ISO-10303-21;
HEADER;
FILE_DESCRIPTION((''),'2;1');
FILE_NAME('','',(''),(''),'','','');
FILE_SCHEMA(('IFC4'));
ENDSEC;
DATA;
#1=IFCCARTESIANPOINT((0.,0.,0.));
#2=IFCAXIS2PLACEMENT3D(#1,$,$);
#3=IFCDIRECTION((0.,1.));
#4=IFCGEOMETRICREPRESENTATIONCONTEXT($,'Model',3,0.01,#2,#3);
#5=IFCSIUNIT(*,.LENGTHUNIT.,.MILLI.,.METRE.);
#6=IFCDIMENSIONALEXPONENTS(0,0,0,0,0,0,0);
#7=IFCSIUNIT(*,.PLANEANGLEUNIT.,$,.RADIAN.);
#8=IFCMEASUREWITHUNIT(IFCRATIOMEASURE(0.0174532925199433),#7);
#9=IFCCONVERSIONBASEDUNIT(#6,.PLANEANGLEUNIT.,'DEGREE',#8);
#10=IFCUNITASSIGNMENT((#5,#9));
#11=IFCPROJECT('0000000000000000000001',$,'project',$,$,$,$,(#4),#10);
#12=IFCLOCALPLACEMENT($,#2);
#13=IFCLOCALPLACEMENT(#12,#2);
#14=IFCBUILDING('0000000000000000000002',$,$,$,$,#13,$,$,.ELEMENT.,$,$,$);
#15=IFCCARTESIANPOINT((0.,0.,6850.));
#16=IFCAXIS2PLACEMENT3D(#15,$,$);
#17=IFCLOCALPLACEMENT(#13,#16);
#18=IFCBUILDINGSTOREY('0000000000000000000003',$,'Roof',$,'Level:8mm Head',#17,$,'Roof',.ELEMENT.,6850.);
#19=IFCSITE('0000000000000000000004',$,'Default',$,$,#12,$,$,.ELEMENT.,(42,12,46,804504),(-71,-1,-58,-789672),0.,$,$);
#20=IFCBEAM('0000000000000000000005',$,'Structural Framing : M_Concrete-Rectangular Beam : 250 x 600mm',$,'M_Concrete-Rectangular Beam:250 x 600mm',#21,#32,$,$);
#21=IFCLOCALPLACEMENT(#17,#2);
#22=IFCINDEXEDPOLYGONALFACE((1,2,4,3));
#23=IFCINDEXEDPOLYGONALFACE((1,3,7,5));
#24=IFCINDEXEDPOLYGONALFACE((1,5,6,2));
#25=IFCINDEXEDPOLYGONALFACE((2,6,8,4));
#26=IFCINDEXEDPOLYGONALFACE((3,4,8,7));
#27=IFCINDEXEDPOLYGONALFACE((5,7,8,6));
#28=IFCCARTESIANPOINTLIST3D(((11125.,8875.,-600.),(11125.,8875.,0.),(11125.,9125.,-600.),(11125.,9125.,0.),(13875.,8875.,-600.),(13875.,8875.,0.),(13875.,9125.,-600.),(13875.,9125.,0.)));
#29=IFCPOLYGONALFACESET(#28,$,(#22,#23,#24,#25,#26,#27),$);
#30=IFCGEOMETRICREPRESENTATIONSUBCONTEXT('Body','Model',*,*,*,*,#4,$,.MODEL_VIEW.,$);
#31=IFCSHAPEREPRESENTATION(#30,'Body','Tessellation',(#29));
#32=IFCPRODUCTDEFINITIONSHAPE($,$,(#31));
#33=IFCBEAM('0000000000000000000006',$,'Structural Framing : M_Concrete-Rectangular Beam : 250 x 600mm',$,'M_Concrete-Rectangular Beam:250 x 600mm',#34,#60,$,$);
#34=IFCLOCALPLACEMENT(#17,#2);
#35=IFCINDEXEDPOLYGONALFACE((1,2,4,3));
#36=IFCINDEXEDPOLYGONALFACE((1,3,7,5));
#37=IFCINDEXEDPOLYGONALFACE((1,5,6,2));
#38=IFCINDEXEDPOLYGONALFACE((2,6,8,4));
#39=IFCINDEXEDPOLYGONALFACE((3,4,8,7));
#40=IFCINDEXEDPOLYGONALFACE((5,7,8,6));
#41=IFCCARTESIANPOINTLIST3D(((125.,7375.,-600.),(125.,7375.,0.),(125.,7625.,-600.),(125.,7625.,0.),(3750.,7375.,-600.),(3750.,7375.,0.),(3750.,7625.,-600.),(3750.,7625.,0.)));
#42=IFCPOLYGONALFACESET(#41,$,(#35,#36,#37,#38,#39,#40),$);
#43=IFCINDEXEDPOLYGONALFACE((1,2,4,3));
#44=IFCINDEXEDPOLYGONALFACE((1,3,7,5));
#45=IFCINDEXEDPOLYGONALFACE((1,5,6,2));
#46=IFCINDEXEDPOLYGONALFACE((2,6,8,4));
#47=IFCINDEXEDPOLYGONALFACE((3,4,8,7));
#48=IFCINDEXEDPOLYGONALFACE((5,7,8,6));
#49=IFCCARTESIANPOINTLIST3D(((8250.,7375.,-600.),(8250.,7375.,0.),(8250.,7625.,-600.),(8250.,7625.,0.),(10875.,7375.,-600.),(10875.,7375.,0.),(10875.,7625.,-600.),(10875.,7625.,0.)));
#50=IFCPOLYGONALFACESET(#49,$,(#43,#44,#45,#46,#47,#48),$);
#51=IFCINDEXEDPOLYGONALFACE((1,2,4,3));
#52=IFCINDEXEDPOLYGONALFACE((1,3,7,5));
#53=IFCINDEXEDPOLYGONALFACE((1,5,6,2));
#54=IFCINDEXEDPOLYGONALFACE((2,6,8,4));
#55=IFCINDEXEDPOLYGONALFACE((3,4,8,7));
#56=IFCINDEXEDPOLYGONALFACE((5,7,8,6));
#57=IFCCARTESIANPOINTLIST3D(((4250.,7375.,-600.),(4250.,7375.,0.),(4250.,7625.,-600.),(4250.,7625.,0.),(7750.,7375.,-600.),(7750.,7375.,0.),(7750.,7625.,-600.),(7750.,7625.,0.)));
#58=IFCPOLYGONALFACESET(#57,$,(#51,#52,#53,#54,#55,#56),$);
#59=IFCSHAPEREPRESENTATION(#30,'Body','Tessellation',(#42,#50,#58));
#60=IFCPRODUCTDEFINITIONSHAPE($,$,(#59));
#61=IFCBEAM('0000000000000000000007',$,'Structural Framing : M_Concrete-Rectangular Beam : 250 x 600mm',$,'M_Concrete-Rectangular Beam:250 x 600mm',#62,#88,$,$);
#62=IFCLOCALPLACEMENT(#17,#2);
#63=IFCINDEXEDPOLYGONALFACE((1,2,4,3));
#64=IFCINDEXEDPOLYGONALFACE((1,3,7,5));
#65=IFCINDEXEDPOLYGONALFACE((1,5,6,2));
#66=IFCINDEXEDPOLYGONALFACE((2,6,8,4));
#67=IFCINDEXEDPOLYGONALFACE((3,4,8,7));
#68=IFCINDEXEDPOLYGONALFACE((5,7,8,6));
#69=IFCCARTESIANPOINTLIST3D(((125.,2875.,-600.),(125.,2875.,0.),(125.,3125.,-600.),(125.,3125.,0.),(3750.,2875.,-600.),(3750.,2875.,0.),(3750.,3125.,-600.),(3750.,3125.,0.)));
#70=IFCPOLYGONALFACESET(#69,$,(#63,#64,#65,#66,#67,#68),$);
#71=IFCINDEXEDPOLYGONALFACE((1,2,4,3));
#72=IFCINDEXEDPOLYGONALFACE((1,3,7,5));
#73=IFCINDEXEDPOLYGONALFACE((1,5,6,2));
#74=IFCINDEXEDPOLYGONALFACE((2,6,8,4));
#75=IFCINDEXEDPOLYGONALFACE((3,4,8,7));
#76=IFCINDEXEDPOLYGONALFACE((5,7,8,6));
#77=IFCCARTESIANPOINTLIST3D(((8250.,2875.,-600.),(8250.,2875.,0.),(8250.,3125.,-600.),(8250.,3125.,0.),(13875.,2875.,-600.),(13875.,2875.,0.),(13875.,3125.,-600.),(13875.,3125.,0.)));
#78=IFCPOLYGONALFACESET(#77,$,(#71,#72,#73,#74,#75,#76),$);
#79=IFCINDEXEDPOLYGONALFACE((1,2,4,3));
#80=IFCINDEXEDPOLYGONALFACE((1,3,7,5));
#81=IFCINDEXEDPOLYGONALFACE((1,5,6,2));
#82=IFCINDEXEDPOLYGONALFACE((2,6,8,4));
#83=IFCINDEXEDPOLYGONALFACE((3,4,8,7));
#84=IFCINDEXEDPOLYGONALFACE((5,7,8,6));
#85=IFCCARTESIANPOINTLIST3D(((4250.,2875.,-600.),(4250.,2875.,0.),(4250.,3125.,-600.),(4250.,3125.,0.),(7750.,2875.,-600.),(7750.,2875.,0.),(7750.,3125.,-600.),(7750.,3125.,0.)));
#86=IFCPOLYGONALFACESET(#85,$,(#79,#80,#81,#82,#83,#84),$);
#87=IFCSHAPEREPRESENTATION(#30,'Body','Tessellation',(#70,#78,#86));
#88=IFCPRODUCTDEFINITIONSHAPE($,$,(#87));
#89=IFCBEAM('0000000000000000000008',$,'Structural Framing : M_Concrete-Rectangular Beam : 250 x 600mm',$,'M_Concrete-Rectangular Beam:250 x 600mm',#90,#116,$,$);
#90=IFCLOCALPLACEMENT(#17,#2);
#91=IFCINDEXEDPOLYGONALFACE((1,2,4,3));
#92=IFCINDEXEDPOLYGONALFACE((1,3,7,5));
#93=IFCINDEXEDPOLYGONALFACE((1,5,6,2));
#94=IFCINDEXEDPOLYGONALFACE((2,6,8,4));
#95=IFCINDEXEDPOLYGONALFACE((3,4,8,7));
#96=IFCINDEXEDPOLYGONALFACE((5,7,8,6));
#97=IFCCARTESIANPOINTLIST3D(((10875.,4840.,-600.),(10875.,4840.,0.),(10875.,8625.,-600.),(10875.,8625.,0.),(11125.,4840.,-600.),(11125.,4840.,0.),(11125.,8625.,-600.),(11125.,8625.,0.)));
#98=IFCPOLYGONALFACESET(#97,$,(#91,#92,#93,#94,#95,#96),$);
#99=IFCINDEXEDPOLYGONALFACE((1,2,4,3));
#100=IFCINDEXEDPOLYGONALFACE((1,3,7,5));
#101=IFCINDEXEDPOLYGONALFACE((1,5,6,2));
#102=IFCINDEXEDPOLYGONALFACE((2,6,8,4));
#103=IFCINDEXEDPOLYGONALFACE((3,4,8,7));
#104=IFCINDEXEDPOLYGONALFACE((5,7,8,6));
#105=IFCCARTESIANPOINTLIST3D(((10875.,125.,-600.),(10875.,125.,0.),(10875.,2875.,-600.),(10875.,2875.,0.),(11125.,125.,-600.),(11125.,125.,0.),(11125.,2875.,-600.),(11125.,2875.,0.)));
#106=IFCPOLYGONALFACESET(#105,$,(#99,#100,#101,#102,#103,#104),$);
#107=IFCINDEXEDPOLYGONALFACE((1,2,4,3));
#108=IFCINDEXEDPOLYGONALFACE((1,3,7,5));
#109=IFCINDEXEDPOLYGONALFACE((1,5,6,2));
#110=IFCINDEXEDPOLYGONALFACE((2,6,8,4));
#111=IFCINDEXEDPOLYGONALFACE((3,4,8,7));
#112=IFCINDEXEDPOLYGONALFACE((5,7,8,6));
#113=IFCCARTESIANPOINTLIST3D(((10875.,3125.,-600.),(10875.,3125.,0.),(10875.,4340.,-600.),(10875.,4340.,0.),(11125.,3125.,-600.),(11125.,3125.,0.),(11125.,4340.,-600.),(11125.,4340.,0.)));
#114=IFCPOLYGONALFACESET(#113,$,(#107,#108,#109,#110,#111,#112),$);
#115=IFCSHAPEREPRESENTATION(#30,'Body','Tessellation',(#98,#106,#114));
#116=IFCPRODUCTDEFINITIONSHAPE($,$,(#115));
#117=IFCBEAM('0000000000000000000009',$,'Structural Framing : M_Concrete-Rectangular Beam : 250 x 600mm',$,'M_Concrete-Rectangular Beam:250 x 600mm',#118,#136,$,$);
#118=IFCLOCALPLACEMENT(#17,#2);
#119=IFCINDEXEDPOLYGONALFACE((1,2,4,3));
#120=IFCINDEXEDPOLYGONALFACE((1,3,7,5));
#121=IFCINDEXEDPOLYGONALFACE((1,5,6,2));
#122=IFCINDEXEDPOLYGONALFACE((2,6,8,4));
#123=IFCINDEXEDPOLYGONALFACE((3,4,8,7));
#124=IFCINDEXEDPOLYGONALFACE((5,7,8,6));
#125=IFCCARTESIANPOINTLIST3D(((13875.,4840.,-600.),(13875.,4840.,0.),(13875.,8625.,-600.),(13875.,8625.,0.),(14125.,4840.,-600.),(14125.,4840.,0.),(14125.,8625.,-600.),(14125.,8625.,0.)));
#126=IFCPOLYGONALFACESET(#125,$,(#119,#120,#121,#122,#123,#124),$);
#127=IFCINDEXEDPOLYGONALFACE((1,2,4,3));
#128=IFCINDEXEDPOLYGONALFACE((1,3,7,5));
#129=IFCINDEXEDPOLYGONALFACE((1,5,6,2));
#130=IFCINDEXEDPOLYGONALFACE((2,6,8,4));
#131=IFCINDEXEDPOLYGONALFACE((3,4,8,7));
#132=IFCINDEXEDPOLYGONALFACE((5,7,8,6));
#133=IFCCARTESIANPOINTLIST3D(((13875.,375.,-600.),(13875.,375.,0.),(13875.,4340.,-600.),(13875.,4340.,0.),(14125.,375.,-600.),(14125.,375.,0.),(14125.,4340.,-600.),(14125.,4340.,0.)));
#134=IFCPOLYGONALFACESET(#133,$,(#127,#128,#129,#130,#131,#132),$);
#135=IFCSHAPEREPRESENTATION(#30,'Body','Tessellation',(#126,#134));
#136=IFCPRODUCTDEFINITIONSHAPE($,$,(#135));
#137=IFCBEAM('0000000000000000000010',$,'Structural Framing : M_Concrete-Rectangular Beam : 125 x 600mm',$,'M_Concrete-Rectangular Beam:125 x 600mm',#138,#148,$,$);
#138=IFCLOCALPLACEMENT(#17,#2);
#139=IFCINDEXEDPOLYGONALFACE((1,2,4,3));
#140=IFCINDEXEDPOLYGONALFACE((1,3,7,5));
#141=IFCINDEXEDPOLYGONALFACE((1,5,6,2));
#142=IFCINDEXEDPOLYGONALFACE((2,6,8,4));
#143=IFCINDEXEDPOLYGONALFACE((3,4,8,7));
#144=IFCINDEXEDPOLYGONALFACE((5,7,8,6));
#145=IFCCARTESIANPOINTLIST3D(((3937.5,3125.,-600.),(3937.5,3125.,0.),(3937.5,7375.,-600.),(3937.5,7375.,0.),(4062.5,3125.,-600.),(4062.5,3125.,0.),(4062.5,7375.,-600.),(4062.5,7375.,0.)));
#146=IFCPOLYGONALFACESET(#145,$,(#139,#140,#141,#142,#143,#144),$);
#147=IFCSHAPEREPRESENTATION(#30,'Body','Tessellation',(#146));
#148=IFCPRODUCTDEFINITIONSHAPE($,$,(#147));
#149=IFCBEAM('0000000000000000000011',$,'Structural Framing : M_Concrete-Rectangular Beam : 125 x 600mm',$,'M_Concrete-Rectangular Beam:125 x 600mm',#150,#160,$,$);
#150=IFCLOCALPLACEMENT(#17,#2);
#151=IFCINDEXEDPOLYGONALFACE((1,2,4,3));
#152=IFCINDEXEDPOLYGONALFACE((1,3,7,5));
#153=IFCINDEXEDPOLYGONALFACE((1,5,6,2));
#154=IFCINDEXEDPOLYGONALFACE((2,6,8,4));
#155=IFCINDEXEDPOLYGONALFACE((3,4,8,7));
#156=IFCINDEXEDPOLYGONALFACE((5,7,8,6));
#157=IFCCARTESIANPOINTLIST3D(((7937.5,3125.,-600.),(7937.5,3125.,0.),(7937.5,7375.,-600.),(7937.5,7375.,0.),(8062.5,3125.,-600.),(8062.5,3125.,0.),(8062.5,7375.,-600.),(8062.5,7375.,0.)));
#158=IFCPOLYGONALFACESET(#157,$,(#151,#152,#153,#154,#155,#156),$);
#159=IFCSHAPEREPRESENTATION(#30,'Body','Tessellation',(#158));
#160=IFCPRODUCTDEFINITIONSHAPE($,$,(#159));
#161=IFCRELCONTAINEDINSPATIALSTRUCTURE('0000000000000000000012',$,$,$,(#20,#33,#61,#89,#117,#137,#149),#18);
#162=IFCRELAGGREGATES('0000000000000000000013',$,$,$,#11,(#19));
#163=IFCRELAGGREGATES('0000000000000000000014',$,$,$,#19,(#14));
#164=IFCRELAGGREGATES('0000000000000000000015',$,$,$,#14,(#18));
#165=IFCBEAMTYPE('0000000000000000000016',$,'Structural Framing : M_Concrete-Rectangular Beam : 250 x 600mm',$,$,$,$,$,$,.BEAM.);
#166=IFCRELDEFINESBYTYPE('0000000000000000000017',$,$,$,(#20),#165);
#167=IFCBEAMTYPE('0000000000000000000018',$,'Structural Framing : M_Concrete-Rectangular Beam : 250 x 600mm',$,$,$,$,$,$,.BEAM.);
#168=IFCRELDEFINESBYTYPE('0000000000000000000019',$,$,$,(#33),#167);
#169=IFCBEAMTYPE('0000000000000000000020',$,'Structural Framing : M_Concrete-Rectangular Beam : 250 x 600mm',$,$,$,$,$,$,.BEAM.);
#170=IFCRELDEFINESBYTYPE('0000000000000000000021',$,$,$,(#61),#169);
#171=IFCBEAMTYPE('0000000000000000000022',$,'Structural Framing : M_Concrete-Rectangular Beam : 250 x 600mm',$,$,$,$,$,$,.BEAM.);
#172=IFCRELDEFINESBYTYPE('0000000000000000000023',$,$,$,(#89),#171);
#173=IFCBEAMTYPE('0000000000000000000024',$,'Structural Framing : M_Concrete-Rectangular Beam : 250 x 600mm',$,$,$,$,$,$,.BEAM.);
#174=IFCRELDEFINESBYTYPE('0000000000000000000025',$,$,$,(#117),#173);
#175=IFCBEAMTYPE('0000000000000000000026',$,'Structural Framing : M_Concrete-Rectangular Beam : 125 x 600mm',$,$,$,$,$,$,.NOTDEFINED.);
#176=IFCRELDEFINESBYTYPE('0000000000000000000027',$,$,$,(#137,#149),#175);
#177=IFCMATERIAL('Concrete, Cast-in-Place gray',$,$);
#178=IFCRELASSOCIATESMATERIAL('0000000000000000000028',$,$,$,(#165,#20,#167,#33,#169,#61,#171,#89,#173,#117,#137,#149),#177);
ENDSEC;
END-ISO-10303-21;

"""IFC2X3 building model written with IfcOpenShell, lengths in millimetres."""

from ifc_helpers import new_model, entity, si_unit, converted_unit, direction, frame, frame_2d, origin, place, context, subcontext, project, spatial, rectangle, extrude, source, transform, mapped, material, type_object, type_shapes, element, save


model = new_model("IFC2X3")

# Units and contexts
model_context = context("Model", 3, precision=0.01, world=origin(), true_north=direction((0.0, 1.0)))
body_context = subcontext(model_context, "Body", "Model", "MODEL_VIEW")
ifc_project = project(units=[si_unit("LENGTHUNIT", "METRE", prefix="MILLI"), converted_unit("PLANEANGLEUNIT", "DEGREE", entity("IfcRatioMeasure", 0.0174532925199433), si_unit("PLANEANGLEUNIT", "RADIAN"), dimensions=[0, 0, 0, 0, 0, 0, 0])], contexts=[model_context])

# Site, building, storey
site_placement = place(None, origin())
site = spatial("IfcSite", under=ifc_project, at=site_placement, Name="Default", CompositionType="ELEMENT", RefLatitude=(42, 12, 46, 804504), RefLongitude=(-71, -1, -58, -789672), RefElevation=0.0)
building_placement = place(site_placement, origin())
building = spatial("IfcBuilding", under=site, at=building_placement, CompositionType="ELEMENT")
storey_placement = place(building_placement, frame((0.0, 0.0, 6850.0)))
storey = spatial("IfcBuildingStorey", under=building, at=storey_placement, Name="Roof", ObjectType="Level:8mm Head", LongName="Roof", CompositionType="ELEMENT", Elevation=6850.0)

# Beams
ifc_material = material(Name="Concrete, Cast-in-Place gray")
beam_type_1 = type_object("IfcBeamType", Name="Structural Framing : M_Concrete-Rectangular Beam : 250 x 600mm", PredefinedType="BEAM", material=ifc_material)
beam_1_placement = place(storey_placement, frame((11000.0, 9000.0, 0.0)))
element("IfcBeam", 1, at=beam_1_placement, inside=storey, type_object=beam_type_1, material=ifc_material, Name="Structural Framing : M_Concrete-Rectangular Beam : 250 x 600mm", ObjectType="M_Concrete-Rectangular Beam:250 x 600mm", context=body_context, shape_type="SweptSolid", body=[
    extrude(rectangle(XDim=600.0, YDim=250.0, at=frame_2d((0.0, 0.0), x_axis=(1.0, 0.0))), frame((125.0, 0.0, -300.0), z_axis=(1.0, 0.0, 0.0), x_axis=(0.0, 0.0, -1.0)), (0.0, 0.0, 1.0), 2750.0),
])
beam_type_2 = type_object("IfcBeamType", Name="Structural Framing : M_Concrete-Rectangular Beam : 250 x 600mm", PredefinedType="BEAM", material=ifc_material)
shared_shape_1 = source(origin(), body_context, "Body", "SweptSolid", [
    extrude(rectangle(XDim=600.0, YDim=250.0, at=frame_2d((0.0, 0.0), x_axis=(1.0, 0.0))), frame((125.0, 7500.0, 6550.0), z_axis=(1.0, 0.0, 0.0), x_axis=(0.0, 0.0, -1.0)), (0.0, 0.0, 1.0), 3625.0),
    extrude(rectangle(XDim=600.0, YDim=250.0, at=frame_2d((0.0, 0.0), x_axis=(1.0, 0.0))), frame((8250.0, 7500.0, 6550.0), z_axis=(1.0, 0.0, 0.0), x_axis=(0.0, 0.0, -1.0)), (0.0, 0.0, 1.0), 2625.0),
    extrude(rectangle(XDim=600.0, YDim=250.0, at=frame_2d((0.0, 0.0), x_axis=(1.0, 0.0))), frame((4250.0, 7500.0, 6550.0), z_axis=(1.0, 0.0, 0.0), x_axis=(0.0, 0.0, -1.0)), (0.0, 0.0, 1.0), 3500.0),
])
type_shapes(beam_type_2, [shared_shape_1])
beam_2_placement = place(storey_placement, frame((0.0, 0.0, -6850.0)))
element("IfcBeam", 2, at=beam_2_placement, inside=storey, type_object=beam_type_2, material=ifc_material, Name="Structural Framing : M_Concrete-Rectangular Beam : 250 x 600mm", ObjectType="M_Concrete-Rectangular Beam:250 x 600mm", context=body_context, shape_type="MappedRepresentation", body=[
    mapped(shared_shape_1, transform((0.0, 0.0, 0.0), scale=1.0)),
])
beam_type_3 = type_object("IfcBeamType", Name="Structural Framing : M_Concrete-Rectangular Beam : 250 x 600mm", PredefinedType="BEAM", material=ifc_material)
shared_shape_2 = source(origin(), body_context, "Body", "SweptSolid", [
    extrude(rectangle(XDim=600.0, YDim=250.0, at=frame_2d((0.0, 0.0), x_axis=(1.0, 0.0))), frame((125.0, 3000.0, 6550.0), z_axis=(1.0, 0.0, 0.0), x_axis=(0.0, 0.0, -1.0)), (0.0, 0.0, 1.0), 3625.0),
    extrude(rectangle(XDim=600.0, YDim=250.0, at=frame_2d((0.0, 0.0), x_axis=(1.0, 0.0))), frame((8250.0, 3000.0, 6550.0), z_axis=(1.0, 0.0, 0.0), x_axis=(0.0, 0.0, -1.0)), (0.0, 0.0, 1.0), 5625.0),
    extrude(rectangle(XDim=600.0, YDim=250.0, at=frame_2d((0.0, 0.0), x_axis=(1.0, 0.0))), frame((4250.0, 3000.0, 6550.0), z_axis=(1.0, 0.0, 0.0), x_axis=(0.0, 0.0, -1.0)), (0.0, 0.0, 1.0), 3500.0),
])
type_shapes(beam_type_3, [shared_shape_2])
beam_3_placement = place(storey_placement, frame((0.0, 0.0, -6850.0)))
element("IfcBeam", 3, at=beam_3_placement, inside=storey, type_object=beam_type_3, material=ifc_material, Name="Structural Framing : M_Concrete-Rectangular Beam : 250 x 600mm", ObjectType="M_Concrete-Rectangular Beam:250 x 600mm", context=body_context, shape_type="MappedRepresentation", body=[
    mapped(shared_shape_2, transform((0.0, 0.0, 0.0), scale=1.0)),
])
beam_type_4 = type_object("IfcBeamType", Name="Structural Framing : M_Concrete-Rectangular Beam : 250 x 600mm", PredefinedType="BEAM", material=ifc_material)
shared_shape_3 = source(origin(), body_context, "Body", "SweptSolid", [
    extrude(rectangle(XDim=600.0, YDim=250.0, at=frame_2d((0.0, 0.0), x_axis=(0.0, 1.0))), frame((11000.0, 4840.0, 6550.0), z_axis=(0.0, 1.0, 0.0), x_axis=(-1.0, 0.0, 0.0)), (0.0, 0.0, 1.0), 3785.0),
    extrude(rectangle(XDim=600.0, YDim=250.0, at=frame_2d((0.0, 0.0), x_axis=(0.0, 1.0))), frame((11000.0, 125.0, 6550.0), z_axis=(0.0, 1.0, 0.0), x_axis=(-1.0, 0.0, 0.0)), (0.0, 0.0, 1.0), 2750.0),
    extrude(rectangle(XDim=600.0, YDim=250.0, at=frame_2d((0.0, 0.0), x_axis=(0.0, 1.0))), frame((11000.0, 3125.0, 6550.0), z_axis=(0.0, 1.0, 0.0), x_axis=(-1.0, 0.0, 0.0)), (0.0, 0.0, 1.0), 1215.0),
])
type_shapes(beam_type_4, [shared_shape_3])
beam_4_placement = place(storey_placement, frame((0.0, 0.0, -6850.0)))
element("IfcBeam", 4, at=beam_4_placement, inside=storey, type_object=beam_type_4, material=ifc_material, Name="Structural Framing : M_Concrete-Rectangular Beam : 250 x 600mm", ObjectType="M_Concrete-Rectangular Beam:250 x 600mm", context=body_context, shape_type="MappedRepresentation", body=[
    mapped(shared_shape_3, transform((0.0, 0.0, 0.0), scale=1.0)),
])
beam_type_5 = type_object("IfcBeamType", Name="Structural Framing : M_Concrete-Rectangular Beam : 250 x 600mm", PredefinedType="BEAM", material=ifc_material)
shared_shape_4 = source(origin(), body_context, "Body", "SweptSolid", [
    extrude(rectangle(XDim=600.0, YDim=250.0, at=frame_2d((0.0, 0.0), x_axis=(0.0, 1.0))), frame((14000.0, 8625.0, 6550.0), z_axis=(0.0, -1.0, 0.0), x_axis=(-1.0, 0.0, 0.0)), (0.0, 0.0, 1.0), 3785.0),
    extrude(rectangle(XDim=600.0, YDim=250.0, at=frame_2d((0.0, 0.0), x_axis=(0.0, 1.0))), frame((14000.0, 4340.0, 6550.0), z_axis=(0.0, -1.0, 0.0), x_axis=(-1.0, 0.0, 0.0)), (0.0, 0.0, 1.0), 3965.0),
])
type_shapes(beam_type_5, [shared_shape_4])
beam_5_placement = place(storey_placement, frame((0.0, 0.0, -6850.0)))
element("IfcBeam", 5, at=beam_5_placement, inside=storey, type_object=beam_type_5, material=ifc_material, Name="Structural Framing : M_Concrete-Rectangular Beam : 250 x 600mm", ObjectType="M_Concrete-Rectangular Beam:250 x 600mm", context=body_context, shape_type="MappedRepresentation", body=[
    mapped(shared_shape_4, transform((0.0, 0.0, 0.0), scale=1.0)),
])
beam_type_6 = type_object("IfcBeamType", Name="Structural Framing : M_Concrete-Rectangular Beam : 125 x 600mm", PredefinedType="NOTDEFINED")
beam_6_placement = place(storey_placement, frame((4000.0, 3000.0, 0.0), z_axis=(0.0, 0.0, 1.0), x_axis=(0.0, 1.0, 0.0)))
element("IfcBeam", 6, at=beam_6_placement, inside=storey, type_object=beam_type_6, material=ifc_material, Name="Structural Framing : M_Concrete-Rectangular Beam : 125 x 600mm", ObjectType="M_Concrete-Rectangular Beam:125 x 600mm", context=body_context, shape_type="SweptSolid", body=[
    extrude(rectangle(XDim=600.0, YDim=125.0, at=frame_2d((0.0, 0.0), x_axis=(1.0, 0.0))), frame((125.0, 0.0, -300.0), z_axis=(1.0, 0.0, 0.0), x_axis=(0.0, 0.0, -1.0)), (0.0, 0.0, 1.0), 4250.0),
])
beam_7_placement = place(storey_placement, frame((8000.0, 3000.0, 0.0), z_axis=(0.0, 0.0, 1.0), x_axis=(0.0, 1.0, 0.0)))
element("IfcBeam", 7, at=beam_7_placement, inside=storey, type_object=beam_type_6, material=ifc_material, Name="Structural Framing : M_Concrete-Rectangular Beam : 125 x 600mm", ObjectType="M_Concrete-Rectangular Beam:125 x 600mm", context=body_context, shape_type="SweptSolid", body=[
    extrude(rectangle(XDim=600.0, YDim=125.0, at=frame_2d((0.0, 0.0), x_axis=(1.0, 0.0))), frame((125.0, 0.0, -300.0), z_axis=(1.0, 0.0, 0.0), x_axis=(0.0, 0.0, -1.0)), (0.0, 0.0, 1.0), 4250.0),
])

save(model, "model.ifc")
